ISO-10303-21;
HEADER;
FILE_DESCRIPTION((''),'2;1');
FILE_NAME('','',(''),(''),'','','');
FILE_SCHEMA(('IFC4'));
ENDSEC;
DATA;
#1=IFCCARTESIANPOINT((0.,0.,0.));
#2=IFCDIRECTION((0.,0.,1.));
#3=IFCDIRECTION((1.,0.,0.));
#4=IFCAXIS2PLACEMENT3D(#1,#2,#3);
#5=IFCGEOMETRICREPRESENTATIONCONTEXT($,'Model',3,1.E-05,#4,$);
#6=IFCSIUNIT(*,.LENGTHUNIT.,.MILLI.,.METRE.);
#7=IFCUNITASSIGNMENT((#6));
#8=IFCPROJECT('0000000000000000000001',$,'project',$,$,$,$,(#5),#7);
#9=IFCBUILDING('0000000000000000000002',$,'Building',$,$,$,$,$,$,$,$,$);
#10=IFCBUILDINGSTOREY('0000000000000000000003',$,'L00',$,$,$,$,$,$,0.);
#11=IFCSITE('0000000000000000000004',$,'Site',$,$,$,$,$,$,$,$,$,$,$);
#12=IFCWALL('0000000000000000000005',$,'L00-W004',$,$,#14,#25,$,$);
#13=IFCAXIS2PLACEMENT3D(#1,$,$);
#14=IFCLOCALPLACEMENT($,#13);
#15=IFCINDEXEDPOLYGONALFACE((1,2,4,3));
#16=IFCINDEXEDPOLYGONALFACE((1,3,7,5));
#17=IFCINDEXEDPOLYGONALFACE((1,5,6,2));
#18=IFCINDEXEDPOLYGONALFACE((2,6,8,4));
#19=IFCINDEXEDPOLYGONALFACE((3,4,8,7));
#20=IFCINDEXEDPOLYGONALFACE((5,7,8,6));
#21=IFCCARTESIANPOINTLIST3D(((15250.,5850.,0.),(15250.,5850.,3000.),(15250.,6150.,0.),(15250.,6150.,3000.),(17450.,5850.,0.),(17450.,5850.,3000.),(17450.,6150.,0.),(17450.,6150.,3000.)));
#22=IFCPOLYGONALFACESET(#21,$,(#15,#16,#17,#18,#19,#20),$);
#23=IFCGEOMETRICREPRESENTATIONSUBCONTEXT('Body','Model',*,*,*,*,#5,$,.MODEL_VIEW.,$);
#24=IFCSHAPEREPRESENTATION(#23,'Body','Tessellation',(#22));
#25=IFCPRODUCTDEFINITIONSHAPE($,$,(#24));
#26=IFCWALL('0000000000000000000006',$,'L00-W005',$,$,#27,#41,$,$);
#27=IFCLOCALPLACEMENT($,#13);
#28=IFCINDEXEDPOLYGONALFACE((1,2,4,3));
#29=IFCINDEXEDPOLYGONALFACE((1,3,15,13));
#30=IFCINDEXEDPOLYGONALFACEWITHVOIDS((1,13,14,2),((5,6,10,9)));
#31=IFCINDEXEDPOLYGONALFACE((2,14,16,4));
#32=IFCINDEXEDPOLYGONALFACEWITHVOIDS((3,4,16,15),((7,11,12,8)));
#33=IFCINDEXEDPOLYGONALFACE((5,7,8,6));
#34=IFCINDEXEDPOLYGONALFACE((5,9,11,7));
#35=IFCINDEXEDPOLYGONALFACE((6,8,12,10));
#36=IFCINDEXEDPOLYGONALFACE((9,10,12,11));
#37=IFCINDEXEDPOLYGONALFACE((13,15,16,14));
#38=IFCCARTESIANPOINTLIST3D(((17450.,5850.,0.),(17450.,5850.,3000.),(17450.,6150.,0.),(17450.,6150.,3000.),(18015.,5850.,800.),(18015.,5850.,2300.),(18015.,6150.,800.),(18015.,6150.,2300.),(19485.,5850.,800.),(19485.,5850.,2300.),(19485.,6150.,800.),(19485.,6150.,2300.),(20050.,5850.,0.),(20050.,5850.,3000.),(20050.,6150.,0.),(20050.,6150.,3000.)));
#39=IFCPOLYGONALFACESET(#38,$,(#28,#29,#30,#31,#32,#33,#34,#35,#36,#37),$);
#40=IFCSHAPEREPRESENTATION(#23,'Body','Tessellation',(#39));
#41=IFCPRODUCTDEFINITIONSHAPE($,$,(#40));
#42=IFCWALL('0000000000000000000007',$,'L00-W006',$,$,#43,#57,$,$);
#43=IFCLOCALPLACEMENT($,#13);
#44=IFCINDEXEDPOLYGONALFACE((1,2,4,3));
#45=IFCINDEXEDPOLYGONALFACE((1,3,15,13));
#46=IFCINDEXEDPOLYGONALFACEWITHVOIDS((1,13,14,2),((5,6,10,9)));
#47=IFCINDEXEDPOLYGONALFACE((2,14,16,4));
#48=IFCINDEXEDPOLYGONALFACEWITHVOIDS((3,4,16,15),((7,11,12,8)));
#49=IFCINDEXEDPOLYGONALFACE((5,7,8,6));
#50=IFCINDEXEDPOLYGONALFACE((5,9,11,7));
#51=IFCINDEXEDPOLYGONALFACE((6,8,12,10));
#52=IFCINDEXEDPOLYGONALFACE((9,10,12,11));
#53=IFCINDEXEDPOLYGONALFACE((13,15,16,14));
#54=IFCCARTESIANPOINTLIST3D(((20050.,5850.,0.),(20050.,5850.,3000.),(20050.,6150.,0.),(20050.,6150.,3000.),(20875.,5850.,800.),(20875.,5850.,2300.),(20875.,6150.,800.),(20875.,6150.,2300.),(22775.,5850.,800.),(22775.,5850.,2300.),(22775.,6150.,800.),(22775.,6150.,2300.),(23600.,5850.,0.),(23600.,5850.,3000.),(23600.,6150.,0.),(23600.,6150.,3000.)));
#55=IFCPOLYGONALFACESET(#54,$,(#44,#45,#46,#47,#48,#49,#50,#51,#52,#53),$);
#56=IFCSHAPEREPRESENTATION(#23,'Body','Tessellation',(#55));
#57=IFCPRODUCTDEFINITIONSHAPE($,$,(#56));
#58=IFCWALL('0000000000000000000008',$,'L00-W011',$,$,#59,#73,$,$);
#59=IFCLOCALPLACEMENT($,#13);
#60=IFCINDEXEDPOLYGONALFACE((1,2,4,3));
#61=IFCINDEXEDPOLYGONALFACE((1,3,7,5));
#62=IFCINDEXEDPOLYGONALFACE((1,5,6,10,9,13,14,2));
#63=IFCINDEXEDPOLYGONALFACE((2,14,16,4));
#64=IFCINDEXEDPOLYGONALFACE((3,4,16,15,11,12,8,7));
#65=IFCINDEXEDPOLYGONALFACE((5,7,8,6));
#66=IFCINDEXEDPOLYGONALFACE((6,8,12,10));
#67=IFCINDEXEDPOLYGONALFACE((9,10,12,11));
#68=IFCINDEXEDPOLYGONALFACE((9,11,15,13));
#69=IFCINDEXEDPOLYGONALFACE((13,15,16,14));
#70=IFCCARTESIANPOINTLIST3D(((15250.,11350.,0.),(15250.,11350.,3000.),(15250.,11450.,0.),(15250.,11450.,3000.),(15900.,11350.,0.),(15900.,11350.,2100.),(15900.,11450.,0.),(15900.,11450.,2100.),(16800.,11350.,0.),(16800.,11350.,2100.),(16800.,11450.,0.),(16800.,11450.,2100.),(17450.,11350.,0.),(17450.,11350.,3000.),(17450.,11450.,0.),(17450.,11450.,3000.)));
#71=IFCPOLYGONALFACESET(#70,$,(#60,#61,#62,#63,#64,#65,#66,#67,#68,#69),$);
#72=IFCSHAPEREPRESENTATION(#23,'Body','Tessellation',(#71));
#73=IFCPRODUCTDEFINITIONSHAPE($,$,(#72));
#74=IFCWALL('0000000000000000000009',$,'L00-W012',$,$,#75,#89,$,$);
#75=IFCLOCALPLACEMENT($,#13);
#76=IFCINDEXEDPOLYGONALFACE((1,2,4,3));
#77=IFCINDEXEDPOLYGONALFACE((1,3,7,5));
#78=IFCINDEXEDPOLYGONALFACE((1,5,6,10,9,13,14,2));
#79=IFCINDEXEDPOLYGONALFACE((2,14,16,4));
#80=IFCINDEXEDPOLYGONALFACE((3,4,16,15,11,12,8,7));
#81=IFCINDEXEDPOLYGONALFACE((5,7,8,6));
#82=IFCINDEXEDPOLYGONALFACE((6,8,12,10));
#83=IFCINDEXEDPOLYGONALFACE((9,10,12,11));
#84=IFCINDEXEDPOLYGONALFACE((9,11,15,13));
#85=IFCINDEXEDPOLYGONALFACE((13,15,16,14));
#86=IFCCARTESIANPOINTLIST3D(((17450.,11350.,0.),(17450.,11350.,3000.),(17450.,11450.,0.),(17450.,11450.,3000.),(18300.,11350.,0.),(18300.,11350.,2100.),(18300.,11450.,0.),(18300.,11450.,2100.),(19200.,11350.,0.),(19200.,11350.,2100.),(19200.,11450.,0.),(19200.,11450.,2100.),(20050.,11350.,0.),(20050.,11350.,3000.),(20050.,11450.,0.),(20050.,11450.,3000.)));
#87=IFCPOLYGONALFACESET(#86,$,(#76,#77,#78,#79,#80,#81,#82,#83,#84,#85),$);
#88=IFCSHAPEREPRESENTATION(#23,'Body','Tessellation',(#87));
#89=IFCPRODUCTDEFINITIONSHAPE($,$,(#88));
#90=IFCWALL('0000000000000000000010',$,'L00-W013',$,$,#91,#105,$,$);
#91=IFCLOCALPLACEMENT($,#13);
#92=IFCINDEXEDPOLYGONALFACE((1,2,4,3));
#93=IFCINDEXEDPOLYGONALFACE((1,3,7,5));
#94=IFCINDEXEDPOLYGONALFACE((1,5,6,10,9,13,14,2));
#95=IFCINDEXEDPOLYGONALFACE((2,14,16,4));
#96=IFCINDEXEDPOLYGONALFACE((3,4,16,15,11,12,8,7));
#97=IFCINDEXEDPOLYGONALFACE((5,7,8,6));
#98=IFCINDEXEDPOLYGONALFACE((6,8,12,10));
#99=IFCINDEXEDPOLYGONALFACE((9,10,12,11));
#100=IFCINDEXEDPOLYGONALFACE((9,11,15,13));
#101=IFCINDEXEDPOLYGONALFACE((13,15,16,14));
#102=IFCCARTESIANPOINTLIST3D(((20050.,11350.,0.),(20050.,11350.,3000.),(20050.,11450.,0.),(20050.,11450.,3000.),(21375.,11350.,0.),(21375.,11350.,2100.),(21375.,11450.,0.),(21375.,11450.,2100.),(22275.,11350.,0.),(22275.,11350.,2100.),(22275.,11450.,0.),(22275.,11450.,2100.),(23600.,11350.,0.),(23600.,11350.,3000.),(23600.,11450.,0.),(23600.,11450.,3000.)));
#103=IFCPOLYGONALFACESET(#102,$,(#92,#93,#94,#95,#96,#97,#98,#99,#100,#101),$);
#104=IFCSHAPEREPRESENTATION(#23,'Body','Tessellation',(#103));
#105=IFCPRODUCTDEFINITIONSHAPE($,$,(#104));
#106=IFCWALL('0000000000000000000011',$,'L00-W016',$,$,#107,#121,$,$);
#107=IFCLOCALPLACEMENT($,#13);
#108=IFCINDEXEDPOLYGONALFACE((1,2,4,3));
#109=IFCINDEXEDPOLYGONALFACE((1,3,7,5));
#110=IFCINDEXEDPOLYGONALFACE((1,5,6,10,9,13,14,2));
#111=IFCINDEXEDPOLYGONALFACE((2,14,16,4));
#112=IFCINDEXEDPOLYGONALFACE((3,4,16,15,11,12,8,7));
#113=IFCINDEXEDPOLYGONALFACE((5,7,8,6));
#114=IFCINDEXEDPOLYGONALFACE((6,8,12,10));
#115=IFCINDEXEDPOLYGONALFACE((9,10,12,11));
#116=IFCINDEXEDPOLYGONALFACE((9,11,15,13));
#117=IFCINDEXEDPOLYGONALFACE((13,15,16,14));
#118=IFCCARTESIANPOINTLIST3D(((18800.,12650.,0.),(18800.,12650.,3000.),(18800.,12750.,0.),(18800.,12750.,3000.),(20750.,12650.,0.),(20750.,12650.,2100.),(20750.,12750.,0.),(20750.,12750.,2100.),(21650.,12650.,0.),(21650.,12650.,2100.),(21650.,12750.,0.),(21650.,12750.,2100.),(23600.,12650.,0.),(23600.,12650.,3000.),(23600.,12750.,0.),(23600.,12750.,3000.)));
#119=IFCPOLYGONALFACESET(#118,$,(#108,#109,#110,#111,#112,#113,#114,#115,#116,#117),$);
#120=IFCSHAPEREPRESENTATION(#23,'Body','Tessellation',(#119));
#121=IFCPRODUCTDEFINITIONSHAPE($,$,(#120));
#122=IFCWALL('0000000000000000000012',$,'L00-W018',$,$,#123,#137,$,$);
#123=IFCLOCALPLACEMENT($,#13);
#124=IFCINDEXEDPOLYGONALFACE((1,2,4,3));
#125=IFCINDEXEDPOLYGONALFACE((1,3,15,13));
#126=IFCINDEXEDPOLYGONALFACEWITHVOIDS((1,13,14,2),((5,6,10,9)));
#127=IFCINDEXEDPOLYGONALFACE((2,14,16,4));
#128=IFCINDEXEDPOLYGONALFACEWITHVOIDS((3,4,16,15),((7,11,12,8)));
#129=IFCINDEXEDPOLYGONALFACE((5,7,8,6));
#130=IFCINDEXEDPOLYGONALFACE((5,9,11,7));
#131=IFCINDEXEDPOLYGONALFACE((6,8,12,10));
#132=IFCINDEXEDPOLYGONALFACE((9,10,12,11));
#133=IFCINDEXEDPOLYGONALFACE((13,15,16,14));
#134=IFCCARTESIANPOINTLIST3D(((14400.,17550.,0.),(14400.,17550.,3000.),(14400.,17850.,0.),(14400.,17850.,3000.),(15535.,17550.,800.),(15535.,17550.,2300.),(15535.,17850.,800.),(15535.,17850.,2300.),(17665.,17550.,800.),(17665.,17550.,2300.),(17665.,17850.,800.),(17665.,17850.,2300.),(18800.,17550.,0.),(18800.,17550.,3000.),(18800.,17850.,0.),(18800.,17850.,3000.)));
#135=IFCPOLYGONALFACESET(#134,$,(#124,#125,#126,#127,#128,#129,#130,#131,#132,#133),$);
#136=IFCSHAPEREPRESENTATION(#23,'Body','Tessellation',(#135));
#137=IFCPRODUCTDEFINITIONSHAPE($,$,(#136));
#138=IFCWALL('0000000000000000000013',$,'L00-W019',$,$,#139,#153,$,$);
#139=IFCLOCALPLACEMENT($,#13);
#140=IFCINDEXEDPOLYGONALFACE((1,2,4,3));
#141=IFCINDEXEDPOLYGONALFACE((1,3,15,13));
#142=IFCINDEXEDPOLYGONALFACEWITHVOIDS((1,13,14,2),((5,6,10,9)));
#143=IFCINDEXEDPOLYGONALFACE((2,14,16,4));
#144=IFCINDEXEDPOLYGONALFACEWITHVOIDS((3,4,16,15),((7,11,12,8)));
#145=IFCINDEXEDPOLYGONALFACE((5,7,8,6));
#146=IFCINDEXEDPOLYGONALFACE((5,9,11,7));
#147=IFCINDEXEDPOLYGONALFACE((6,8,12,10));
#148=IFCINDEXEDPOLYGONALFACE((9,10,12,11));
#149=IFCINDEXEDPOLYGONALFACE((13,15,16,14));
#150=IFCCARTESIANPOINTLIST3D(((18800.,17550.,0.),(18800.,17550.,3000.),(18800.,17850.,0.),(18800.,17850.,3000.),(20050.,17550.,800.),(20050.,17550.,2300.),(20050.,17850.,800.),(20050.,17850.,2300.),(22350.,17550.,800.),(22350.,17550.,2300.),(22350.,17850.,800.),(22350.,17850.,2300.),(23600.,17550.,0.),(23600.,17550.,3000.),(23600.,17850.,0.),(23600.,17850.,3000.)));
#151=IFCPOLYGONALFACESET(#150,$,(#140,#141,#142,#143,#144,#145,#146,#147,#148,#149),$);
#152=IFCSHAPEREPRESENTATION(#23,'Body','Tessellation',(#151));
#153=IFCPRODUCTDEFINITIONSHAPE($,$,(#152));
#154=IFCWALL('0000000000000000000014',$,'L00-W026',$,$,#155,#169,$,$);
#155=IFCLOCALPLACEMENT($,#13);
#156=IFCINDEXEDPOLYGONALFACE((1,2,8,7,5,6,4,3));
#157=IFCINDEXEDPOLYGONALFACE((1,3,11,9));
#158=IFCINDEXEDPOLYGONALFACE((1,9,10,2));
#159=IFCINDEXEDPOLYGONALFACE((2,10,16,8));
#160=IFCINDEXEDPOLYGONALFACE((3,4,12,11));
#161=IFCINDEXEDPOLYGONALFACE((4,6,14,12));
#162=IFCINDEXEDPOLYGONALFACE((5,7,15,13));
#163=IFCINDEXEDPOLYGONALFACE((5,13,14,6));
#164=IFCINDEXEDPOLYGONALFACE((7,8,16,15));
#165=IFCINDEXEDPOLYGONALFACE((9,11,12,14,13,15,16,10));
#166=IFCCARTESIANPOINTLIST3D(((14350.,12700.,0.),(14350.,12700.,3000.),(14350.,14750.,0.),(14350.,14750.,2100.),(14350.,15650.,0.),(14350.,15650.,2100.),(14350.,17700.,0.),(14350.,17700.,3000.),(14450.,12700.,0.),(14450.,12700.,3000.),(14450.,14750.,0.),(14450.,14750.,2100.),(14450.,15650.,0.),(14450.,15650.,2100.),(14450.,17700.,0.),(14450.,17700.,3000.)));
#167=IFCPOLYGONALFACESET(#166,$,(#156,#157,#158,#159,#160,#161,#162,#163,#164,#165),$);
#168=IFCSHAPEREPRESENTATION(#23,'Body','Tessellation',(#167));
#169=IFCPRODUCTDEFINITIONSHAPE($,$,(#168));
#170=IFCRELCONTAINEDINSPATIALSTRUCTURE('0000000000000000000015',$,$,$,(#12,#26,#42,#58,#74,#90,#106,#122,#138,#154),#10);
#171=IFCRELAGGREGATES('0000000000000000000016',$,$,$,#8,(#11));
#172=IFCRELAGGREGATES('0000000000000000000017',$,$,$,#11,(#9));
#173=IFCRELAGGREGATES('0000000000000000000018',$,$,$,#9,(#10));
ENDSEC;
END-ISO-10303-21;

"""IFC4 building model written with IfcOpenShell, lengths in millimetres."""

from ifc_helpers import new_model, si_unit, frame, origin_with_axes, place, context, subcontext, project, spatial, indexed_curve, outline, extrude, element, save


model = new_model("IFC4")

# Units and contexts
model_context = context("Model", 3, precision=1e-05, world=origin_with_axes())
body_context = subcontext(model_context, "Body", "Model", "MODEL_VIEW")
ifc_project = project(units=[si_unit("LENGTHUNIT", "METRE", prefix="MILLI")], contexts=[model_context])

# Site, building, storey
site = spatial("IfcSite", under=ifc_project, Name="Site")
building = spatial("IfcBuilding", under=site, Name="Building")
storey = spatial("IfcBuildingStorey", under=building, Name="L00", Elevation=0.0)

# Wall
wall_1_placement = place(None, frame((15250.0, 5850.0, 0.0), z_axis=(0.0, 0.0, 1.0), x_axis=(1.0, 0.0, 0.0)))
element("IfcWall", 1, at=wall_1_placement, inside=storey, Name="L00-W004", context=body_context, shape_type="SweptSolid", body=[
    extrude(outline(indexed_curve([(0.0, 0.0), (0.0, 300.0), (2200.0, 300.0), (2200.0, 0.0), (0.0, 0.0)], self_intersect=False)), origin_with_axes(), (0.0, 0.0, 1.0), 3000.0),
])

# Walls, openings
wall_2_placement = place(None, frame((17450.0, 5850.0, 0.0), z_axis=(0.0, 0.0, 1.0), x_axis=(1.0, 0.0, 0.0)))
wall_2 = element("IfcWall", 2, at=wall_2_placement, inside=storey, Name="L00-W005", context=body_context, shape_type="SweptSolid", body=[
    extrude(outline(indexed_curve([(0.0, 0.0), (0.0, 300.0), (2600.0, 300.0), (2600.0, 0.0), (0.0, 0.0)], self_intersect=False)), origin_with_axes(), (0.0, 0.0, 1.0), 3000.0),
])
opening_1_placement = place(wall_2_placement, frame((565.0, -10.0, 800.0), z_axis=(0.0, 0.0, 1.0), x_axis=(1.0, 0.0, 0.0)))
element("IfcOpeningElement", 3, at=opening_1_placement, cuts=wall_2, context=body_context, shape_type="SweptSolid", body=[
    extrude(outline(indexed_curve([(0.0, 0.0), (0.0, 320.0), (1470.0, 320.0), (1470.0, 0.0), (0.0, 0.0)], self_intersect=False)), origin_with_axes(), (0.0, 0.0, 1.0), 1500.0),
])
wall_3_placement = place(None, frame((20050.0, 5850.0, 0.0), z_axis=(0.0, 0.0, 1.0), x_axis=(1.0, 0.0, 0.0)))
wall_3 = element("IfcWall", 4, at=wall_3_placement, inside=storey, Name="L00-W006", context=body_context, shape_type="SweptSolid", body=[
    extrude(outline(indexed_curve([(0.0, 0.0), (0.0, 300.0), (3550.0, 300.0), (3550.0, 0.0), (0.0, 0.0)], self_intersect=False)), origin_with_axes(), (0.0, 0.0, 1.0), 3000.0),
])
opening_2_placement = place(wall_3_placement, frame((825.0, -10.0, 800.0), z_axis=(0.0, 0.0, 1.0), x_axis=(1.0, 0.0, 0.0)))
element("IfcOpeningElement", 5, at=opening_2_placement, cuts=wall_3, context=body_context, shape_type="SweptSolid", body=[
    extrude(outline(indexed_curve([(0.0, 0.0), (0.0, 320.0), (1900.0, 320.0), (1900.0, 0.0), (0.0, 0.0)], self_intersect=False)), origin_with_axes(), (0.0, 0.0, 1.0), 1500.0),
])
wall_4_placement = place(None, frame((15250.0, 11350.0, 0.0), z_axis=(0.0, 0.0, 1.0), x_axis=(1.0, 0.0, 0.0)))
wall_4 = element("IfcWall", 6, at=wall_4_placement, inside=storey, Name="L00-W011", context=body_context, shape_type="SweptSolid", body=[
    extrude(outline(indexed_curve([(0.0, 0.0), (0.0, 100.0), (2200.0, 100.0), (2200.0, 0.0), (0.0, 0.0)], self_intersect=False)), origin_with_axes(), (0.0, 0.0, 1.0), 3000.0),
])
opening_3_placement = place(wall_4_placement, frame((650.0, -10.0, 0.0), z_axis=(0.0, 0.0, 1.0), x_axis=(1.0, 0.0, 0.0)))
element("IfcOpeningElement", 7, at=opening_3_placement, cuts=wall_4, context=body_context, shape_type="SweptSolid", body=[
    extrude(outline(indexed_curve([(0.0, 0.0), (0.0, 120.0), (900.0, 120.0), (900.0, 0.0), (0.0, 0.0)], self_intersect=False)), origin_with_axes(), (0.0, 0.0, 1.0), 2100.0),
])
wall_5_placement = place(None, frame((17450.0, 11350.0, 0.0), z_axis=(0.0, 0.0, 1.0), x_axis=(1.0, 0.0, 0.0)))
wall_5 = element("IfcWall", 8, at=wall_5_placement, inside=storey, Name="L00-W012", context=body_context, shape_type="SweptSolid", body=[
    extrude(outline(indexed_curve([(0.0, 0.0), (0.0, 100.0), (2600.0, 100.0), (2600.0, 0.0), (0.0, 0.0)], self_intersect=False)), origin_with_axes(), (0.0, 0.0, 1.0), 3000.0),
])
opening_4_placement = place(wall_5_placement, frame((850.0, -10.0, 0.0), z_axis=(0.0, 0.0, 1.0), x_axis=(1.0, 0.0, 0.0)))
element("IfcOpeningElement", 9, at=opening_4_placement, cuts=wall_5, context=body_context, shape_type="SweptSolid", body=[
    extrude(outline(indexed_curve([(0.0, 0.0), (0.0, 120.0), (900.0, 120.0), (900.0, 0.0), (0.0, 0.0)], self_intersect=False)), origin_with_axes(), (0.0, 0.0, 1.0), 2100.0),
])
wall_6_placement = place(None, frame((20050.0, 11350.0, 0.0), z_axis=(0.0, 0.0, 1.0), x_axis=(1.0, 0.0, 0.0)))
wall_6 = element("IfcWall", 10, at=wall_6_placement, inside=storey, Name="L00-W013", context=body_context, shape_type="SweptSolid", body=[
    extrude(outline(indexed_curve([(0.0, 0.0), (0.0, 100.0), (3550.0, 100.0), (3550.0, 0.0), (0.0, 0.0)], self_intersect=False)), origin_with_axes(), (0.0, 0.0, 1.0), 3000.0),
])
opening_5_placement = place(wall_6_placement, frame((1325.0, -10.0, 0.0), z_axis=(0.0, 0.0, 1.0), x_axis=(1.0, 0.0, 0.0)))
element("IfcOpeningElement", 11, at=opening_5_placement, cuts=wall_6, context=body_context, shape_type="SweptSolid", body=[
    extrude(outline(indexed_curve([(0.0, 0.0), (0.0, 120.0), (900.0, 120.0), (900.0, 0.0), (0.0, 0.0)], self_intersect=False)), origin_with_axes(), (0.0, 0.0, 1.0), 2100.0),
])
wall_7_placement = place(None, frame((18800.0, 12650.0, 0.0), z_axis=(0.0, 0.0, 1.0), x_axis=(1.0, 0.0, 0.0)))
wall_7 = element("IfcWall", 12, at=wall_7_placement, inside=storey, Name="L00-W016", context=body_context, shape_type="SweptSolid", body=[
    extrude(outline(indexed_curve([(0.0, 0.0), (0.0, 100.0), (4800.0, 100.0), (4800.0, 0.0), (0.0, 0.0)], self_intersect=False)), origin_with_axes(), (0.0, 0.0, 1.0), 3000.0),
])
opening_6_placement = place(wall_7_placement, frame((1950.0, -10.0, 0.0), z_axis=(0.0, 0.0, 1.0), x_axis=(1.0, 0.0, 0.0)))
element("IfcOpeningElement", 13, at=opening_6_placement, cuts=wall_7, context=body_context, shape_type="SweptSolid", body=[
    extrude(outline(indexed_curve([(0.0, 0.0), (0.0, 120.0), (900.0, 120.0), (900.0, 0.0), (0.0, 0.0)], self_intersect=False)), origin_with_axes(), (0.0, 0.0, 1.0), 2100.0),
])
wall_8_placement = place(None, frame((14400.0, 17550.0, 0.0), z_axis=(0.0, 0.0, 1.0), x_axis=(1.0, 0.0, 0.0)))
wall_8 = element("IfcWall", 14, at=wall_8_placement, inside=storey, Name="L00-W018", context=body_context, shape_type="SweptSolid", body=[
    extrude(outline(indexed_curve([(0.0, 0.0), (0.0, 300.0), (4400.0, 300.0), (4400.0, 0.0), (0.0, 0.0)], self_intersect=False)), origin_with_axes(), (0.0, 0.0, 1.0), 3000.0),
])
opening_7_placement = place(wall_8_placement, frame((1135.0, -10.0, 800.0), z_axis=(0.0, 0.0, 1.0), x_axis=(1.0, 0.0, 0.0)))
element("IfcOpeningElement", 15, at=opening_7_placement, cuts=wall_8, context=body_context, shape_type="SweptSolid", body=[
    extrude(outline(indexed_curve([(0.0, 0.0), (0.0, 320.0), (2130.0, 320.0), (2130.0, 0.0), (0.0, 0.0)], self_intersect=False)), origin_with_axes(), (0.0, 0.0, 1.0), 1500.0),
])
wall_9_placement = place(None, frame((18800.0, 17550.0, 0.0), z_axis=(0.0, 0.0, 1.0), x_axis=(1.0, 0.0, 0.0)))
wall_9 = element("IfcWall", 16, at=wall_9_placement, inside=storey, Name="L00-W019", context=body_context, shape_type="SweptSolid", body=[
    extrude(outline(indexed_curve([(0.0, 0.0), (0.0, 300.0), (4800.0, 300.0), (4800.0, 0.0), (0.0, 0.0)], self_intersect=False)), origin_with_axes(), (0.0, 0.0, 1.0), 3000.0),
])
opening_8_placement = place(wall_9_placement, frame((1250.0, -10.0, 800.0), z_axis=(0.0, 0.0, 1.0), x_axis=(1.0, 0.0, 0.0)))
element("IfcOpeningElement", 17, at=opening_8_placement, cuts=wall_9, context=body_context, shape_type="SweptSolid", body=[
    extrude(outline(indexed_curve([(0.0, 0.0), (0.0, 320.0), (2300.0, 320.0), (2300.0, 0.0), (0.0, 0.0)], self_intersect=False)), origin_with_axes(), (0.0, 0.0, 1.0), 1500.0),
])
wall_10_placement = place(None, frame((14450.0, 12700.0, 0.0), z_axis=(0.0, 0.0, 1.0), x_axis=(0.0, 1.0, 0.0)))
wall_10 = element("IfcWall", 18, at=wall_10_placement, inside=storey, Name="L00-W026", context=body_context, shape_type="SweptSolid", body=[
    extrude(outline(indexed_curve([(0.0, 0.0), (0.0, 100.0), (5000.0, 100.0), (5000.0, 0.0), (0.0, 0.0)], self_intersect=False)), origin_with_axes(), (0.0, 0.0, 1.0), 3000.0),
])
opening_9_placement = place(wall_10_placement, frame((2050.0, -10.0, 0.0), z_axis=(0.0, 0.0, 1.0), x_axis=(1.0, 0.0, 0.0)))
element("IfcOpeningElement", 19, at=opening_9_placement, cuts=wall_10, context=body_context, shape_type="SweptSolid", body=[
    extrude(outline(indexed_curve([(0.0, 0.0), (0.0, 120.0), (900.0, 120.0), (900.0, 0.0), (0.0, 0.0)], self_intersect=False)), origin_with_axes(), (0.0, 0.0, 1.0), 2100.0),
])

save(model, "model.ifc")
